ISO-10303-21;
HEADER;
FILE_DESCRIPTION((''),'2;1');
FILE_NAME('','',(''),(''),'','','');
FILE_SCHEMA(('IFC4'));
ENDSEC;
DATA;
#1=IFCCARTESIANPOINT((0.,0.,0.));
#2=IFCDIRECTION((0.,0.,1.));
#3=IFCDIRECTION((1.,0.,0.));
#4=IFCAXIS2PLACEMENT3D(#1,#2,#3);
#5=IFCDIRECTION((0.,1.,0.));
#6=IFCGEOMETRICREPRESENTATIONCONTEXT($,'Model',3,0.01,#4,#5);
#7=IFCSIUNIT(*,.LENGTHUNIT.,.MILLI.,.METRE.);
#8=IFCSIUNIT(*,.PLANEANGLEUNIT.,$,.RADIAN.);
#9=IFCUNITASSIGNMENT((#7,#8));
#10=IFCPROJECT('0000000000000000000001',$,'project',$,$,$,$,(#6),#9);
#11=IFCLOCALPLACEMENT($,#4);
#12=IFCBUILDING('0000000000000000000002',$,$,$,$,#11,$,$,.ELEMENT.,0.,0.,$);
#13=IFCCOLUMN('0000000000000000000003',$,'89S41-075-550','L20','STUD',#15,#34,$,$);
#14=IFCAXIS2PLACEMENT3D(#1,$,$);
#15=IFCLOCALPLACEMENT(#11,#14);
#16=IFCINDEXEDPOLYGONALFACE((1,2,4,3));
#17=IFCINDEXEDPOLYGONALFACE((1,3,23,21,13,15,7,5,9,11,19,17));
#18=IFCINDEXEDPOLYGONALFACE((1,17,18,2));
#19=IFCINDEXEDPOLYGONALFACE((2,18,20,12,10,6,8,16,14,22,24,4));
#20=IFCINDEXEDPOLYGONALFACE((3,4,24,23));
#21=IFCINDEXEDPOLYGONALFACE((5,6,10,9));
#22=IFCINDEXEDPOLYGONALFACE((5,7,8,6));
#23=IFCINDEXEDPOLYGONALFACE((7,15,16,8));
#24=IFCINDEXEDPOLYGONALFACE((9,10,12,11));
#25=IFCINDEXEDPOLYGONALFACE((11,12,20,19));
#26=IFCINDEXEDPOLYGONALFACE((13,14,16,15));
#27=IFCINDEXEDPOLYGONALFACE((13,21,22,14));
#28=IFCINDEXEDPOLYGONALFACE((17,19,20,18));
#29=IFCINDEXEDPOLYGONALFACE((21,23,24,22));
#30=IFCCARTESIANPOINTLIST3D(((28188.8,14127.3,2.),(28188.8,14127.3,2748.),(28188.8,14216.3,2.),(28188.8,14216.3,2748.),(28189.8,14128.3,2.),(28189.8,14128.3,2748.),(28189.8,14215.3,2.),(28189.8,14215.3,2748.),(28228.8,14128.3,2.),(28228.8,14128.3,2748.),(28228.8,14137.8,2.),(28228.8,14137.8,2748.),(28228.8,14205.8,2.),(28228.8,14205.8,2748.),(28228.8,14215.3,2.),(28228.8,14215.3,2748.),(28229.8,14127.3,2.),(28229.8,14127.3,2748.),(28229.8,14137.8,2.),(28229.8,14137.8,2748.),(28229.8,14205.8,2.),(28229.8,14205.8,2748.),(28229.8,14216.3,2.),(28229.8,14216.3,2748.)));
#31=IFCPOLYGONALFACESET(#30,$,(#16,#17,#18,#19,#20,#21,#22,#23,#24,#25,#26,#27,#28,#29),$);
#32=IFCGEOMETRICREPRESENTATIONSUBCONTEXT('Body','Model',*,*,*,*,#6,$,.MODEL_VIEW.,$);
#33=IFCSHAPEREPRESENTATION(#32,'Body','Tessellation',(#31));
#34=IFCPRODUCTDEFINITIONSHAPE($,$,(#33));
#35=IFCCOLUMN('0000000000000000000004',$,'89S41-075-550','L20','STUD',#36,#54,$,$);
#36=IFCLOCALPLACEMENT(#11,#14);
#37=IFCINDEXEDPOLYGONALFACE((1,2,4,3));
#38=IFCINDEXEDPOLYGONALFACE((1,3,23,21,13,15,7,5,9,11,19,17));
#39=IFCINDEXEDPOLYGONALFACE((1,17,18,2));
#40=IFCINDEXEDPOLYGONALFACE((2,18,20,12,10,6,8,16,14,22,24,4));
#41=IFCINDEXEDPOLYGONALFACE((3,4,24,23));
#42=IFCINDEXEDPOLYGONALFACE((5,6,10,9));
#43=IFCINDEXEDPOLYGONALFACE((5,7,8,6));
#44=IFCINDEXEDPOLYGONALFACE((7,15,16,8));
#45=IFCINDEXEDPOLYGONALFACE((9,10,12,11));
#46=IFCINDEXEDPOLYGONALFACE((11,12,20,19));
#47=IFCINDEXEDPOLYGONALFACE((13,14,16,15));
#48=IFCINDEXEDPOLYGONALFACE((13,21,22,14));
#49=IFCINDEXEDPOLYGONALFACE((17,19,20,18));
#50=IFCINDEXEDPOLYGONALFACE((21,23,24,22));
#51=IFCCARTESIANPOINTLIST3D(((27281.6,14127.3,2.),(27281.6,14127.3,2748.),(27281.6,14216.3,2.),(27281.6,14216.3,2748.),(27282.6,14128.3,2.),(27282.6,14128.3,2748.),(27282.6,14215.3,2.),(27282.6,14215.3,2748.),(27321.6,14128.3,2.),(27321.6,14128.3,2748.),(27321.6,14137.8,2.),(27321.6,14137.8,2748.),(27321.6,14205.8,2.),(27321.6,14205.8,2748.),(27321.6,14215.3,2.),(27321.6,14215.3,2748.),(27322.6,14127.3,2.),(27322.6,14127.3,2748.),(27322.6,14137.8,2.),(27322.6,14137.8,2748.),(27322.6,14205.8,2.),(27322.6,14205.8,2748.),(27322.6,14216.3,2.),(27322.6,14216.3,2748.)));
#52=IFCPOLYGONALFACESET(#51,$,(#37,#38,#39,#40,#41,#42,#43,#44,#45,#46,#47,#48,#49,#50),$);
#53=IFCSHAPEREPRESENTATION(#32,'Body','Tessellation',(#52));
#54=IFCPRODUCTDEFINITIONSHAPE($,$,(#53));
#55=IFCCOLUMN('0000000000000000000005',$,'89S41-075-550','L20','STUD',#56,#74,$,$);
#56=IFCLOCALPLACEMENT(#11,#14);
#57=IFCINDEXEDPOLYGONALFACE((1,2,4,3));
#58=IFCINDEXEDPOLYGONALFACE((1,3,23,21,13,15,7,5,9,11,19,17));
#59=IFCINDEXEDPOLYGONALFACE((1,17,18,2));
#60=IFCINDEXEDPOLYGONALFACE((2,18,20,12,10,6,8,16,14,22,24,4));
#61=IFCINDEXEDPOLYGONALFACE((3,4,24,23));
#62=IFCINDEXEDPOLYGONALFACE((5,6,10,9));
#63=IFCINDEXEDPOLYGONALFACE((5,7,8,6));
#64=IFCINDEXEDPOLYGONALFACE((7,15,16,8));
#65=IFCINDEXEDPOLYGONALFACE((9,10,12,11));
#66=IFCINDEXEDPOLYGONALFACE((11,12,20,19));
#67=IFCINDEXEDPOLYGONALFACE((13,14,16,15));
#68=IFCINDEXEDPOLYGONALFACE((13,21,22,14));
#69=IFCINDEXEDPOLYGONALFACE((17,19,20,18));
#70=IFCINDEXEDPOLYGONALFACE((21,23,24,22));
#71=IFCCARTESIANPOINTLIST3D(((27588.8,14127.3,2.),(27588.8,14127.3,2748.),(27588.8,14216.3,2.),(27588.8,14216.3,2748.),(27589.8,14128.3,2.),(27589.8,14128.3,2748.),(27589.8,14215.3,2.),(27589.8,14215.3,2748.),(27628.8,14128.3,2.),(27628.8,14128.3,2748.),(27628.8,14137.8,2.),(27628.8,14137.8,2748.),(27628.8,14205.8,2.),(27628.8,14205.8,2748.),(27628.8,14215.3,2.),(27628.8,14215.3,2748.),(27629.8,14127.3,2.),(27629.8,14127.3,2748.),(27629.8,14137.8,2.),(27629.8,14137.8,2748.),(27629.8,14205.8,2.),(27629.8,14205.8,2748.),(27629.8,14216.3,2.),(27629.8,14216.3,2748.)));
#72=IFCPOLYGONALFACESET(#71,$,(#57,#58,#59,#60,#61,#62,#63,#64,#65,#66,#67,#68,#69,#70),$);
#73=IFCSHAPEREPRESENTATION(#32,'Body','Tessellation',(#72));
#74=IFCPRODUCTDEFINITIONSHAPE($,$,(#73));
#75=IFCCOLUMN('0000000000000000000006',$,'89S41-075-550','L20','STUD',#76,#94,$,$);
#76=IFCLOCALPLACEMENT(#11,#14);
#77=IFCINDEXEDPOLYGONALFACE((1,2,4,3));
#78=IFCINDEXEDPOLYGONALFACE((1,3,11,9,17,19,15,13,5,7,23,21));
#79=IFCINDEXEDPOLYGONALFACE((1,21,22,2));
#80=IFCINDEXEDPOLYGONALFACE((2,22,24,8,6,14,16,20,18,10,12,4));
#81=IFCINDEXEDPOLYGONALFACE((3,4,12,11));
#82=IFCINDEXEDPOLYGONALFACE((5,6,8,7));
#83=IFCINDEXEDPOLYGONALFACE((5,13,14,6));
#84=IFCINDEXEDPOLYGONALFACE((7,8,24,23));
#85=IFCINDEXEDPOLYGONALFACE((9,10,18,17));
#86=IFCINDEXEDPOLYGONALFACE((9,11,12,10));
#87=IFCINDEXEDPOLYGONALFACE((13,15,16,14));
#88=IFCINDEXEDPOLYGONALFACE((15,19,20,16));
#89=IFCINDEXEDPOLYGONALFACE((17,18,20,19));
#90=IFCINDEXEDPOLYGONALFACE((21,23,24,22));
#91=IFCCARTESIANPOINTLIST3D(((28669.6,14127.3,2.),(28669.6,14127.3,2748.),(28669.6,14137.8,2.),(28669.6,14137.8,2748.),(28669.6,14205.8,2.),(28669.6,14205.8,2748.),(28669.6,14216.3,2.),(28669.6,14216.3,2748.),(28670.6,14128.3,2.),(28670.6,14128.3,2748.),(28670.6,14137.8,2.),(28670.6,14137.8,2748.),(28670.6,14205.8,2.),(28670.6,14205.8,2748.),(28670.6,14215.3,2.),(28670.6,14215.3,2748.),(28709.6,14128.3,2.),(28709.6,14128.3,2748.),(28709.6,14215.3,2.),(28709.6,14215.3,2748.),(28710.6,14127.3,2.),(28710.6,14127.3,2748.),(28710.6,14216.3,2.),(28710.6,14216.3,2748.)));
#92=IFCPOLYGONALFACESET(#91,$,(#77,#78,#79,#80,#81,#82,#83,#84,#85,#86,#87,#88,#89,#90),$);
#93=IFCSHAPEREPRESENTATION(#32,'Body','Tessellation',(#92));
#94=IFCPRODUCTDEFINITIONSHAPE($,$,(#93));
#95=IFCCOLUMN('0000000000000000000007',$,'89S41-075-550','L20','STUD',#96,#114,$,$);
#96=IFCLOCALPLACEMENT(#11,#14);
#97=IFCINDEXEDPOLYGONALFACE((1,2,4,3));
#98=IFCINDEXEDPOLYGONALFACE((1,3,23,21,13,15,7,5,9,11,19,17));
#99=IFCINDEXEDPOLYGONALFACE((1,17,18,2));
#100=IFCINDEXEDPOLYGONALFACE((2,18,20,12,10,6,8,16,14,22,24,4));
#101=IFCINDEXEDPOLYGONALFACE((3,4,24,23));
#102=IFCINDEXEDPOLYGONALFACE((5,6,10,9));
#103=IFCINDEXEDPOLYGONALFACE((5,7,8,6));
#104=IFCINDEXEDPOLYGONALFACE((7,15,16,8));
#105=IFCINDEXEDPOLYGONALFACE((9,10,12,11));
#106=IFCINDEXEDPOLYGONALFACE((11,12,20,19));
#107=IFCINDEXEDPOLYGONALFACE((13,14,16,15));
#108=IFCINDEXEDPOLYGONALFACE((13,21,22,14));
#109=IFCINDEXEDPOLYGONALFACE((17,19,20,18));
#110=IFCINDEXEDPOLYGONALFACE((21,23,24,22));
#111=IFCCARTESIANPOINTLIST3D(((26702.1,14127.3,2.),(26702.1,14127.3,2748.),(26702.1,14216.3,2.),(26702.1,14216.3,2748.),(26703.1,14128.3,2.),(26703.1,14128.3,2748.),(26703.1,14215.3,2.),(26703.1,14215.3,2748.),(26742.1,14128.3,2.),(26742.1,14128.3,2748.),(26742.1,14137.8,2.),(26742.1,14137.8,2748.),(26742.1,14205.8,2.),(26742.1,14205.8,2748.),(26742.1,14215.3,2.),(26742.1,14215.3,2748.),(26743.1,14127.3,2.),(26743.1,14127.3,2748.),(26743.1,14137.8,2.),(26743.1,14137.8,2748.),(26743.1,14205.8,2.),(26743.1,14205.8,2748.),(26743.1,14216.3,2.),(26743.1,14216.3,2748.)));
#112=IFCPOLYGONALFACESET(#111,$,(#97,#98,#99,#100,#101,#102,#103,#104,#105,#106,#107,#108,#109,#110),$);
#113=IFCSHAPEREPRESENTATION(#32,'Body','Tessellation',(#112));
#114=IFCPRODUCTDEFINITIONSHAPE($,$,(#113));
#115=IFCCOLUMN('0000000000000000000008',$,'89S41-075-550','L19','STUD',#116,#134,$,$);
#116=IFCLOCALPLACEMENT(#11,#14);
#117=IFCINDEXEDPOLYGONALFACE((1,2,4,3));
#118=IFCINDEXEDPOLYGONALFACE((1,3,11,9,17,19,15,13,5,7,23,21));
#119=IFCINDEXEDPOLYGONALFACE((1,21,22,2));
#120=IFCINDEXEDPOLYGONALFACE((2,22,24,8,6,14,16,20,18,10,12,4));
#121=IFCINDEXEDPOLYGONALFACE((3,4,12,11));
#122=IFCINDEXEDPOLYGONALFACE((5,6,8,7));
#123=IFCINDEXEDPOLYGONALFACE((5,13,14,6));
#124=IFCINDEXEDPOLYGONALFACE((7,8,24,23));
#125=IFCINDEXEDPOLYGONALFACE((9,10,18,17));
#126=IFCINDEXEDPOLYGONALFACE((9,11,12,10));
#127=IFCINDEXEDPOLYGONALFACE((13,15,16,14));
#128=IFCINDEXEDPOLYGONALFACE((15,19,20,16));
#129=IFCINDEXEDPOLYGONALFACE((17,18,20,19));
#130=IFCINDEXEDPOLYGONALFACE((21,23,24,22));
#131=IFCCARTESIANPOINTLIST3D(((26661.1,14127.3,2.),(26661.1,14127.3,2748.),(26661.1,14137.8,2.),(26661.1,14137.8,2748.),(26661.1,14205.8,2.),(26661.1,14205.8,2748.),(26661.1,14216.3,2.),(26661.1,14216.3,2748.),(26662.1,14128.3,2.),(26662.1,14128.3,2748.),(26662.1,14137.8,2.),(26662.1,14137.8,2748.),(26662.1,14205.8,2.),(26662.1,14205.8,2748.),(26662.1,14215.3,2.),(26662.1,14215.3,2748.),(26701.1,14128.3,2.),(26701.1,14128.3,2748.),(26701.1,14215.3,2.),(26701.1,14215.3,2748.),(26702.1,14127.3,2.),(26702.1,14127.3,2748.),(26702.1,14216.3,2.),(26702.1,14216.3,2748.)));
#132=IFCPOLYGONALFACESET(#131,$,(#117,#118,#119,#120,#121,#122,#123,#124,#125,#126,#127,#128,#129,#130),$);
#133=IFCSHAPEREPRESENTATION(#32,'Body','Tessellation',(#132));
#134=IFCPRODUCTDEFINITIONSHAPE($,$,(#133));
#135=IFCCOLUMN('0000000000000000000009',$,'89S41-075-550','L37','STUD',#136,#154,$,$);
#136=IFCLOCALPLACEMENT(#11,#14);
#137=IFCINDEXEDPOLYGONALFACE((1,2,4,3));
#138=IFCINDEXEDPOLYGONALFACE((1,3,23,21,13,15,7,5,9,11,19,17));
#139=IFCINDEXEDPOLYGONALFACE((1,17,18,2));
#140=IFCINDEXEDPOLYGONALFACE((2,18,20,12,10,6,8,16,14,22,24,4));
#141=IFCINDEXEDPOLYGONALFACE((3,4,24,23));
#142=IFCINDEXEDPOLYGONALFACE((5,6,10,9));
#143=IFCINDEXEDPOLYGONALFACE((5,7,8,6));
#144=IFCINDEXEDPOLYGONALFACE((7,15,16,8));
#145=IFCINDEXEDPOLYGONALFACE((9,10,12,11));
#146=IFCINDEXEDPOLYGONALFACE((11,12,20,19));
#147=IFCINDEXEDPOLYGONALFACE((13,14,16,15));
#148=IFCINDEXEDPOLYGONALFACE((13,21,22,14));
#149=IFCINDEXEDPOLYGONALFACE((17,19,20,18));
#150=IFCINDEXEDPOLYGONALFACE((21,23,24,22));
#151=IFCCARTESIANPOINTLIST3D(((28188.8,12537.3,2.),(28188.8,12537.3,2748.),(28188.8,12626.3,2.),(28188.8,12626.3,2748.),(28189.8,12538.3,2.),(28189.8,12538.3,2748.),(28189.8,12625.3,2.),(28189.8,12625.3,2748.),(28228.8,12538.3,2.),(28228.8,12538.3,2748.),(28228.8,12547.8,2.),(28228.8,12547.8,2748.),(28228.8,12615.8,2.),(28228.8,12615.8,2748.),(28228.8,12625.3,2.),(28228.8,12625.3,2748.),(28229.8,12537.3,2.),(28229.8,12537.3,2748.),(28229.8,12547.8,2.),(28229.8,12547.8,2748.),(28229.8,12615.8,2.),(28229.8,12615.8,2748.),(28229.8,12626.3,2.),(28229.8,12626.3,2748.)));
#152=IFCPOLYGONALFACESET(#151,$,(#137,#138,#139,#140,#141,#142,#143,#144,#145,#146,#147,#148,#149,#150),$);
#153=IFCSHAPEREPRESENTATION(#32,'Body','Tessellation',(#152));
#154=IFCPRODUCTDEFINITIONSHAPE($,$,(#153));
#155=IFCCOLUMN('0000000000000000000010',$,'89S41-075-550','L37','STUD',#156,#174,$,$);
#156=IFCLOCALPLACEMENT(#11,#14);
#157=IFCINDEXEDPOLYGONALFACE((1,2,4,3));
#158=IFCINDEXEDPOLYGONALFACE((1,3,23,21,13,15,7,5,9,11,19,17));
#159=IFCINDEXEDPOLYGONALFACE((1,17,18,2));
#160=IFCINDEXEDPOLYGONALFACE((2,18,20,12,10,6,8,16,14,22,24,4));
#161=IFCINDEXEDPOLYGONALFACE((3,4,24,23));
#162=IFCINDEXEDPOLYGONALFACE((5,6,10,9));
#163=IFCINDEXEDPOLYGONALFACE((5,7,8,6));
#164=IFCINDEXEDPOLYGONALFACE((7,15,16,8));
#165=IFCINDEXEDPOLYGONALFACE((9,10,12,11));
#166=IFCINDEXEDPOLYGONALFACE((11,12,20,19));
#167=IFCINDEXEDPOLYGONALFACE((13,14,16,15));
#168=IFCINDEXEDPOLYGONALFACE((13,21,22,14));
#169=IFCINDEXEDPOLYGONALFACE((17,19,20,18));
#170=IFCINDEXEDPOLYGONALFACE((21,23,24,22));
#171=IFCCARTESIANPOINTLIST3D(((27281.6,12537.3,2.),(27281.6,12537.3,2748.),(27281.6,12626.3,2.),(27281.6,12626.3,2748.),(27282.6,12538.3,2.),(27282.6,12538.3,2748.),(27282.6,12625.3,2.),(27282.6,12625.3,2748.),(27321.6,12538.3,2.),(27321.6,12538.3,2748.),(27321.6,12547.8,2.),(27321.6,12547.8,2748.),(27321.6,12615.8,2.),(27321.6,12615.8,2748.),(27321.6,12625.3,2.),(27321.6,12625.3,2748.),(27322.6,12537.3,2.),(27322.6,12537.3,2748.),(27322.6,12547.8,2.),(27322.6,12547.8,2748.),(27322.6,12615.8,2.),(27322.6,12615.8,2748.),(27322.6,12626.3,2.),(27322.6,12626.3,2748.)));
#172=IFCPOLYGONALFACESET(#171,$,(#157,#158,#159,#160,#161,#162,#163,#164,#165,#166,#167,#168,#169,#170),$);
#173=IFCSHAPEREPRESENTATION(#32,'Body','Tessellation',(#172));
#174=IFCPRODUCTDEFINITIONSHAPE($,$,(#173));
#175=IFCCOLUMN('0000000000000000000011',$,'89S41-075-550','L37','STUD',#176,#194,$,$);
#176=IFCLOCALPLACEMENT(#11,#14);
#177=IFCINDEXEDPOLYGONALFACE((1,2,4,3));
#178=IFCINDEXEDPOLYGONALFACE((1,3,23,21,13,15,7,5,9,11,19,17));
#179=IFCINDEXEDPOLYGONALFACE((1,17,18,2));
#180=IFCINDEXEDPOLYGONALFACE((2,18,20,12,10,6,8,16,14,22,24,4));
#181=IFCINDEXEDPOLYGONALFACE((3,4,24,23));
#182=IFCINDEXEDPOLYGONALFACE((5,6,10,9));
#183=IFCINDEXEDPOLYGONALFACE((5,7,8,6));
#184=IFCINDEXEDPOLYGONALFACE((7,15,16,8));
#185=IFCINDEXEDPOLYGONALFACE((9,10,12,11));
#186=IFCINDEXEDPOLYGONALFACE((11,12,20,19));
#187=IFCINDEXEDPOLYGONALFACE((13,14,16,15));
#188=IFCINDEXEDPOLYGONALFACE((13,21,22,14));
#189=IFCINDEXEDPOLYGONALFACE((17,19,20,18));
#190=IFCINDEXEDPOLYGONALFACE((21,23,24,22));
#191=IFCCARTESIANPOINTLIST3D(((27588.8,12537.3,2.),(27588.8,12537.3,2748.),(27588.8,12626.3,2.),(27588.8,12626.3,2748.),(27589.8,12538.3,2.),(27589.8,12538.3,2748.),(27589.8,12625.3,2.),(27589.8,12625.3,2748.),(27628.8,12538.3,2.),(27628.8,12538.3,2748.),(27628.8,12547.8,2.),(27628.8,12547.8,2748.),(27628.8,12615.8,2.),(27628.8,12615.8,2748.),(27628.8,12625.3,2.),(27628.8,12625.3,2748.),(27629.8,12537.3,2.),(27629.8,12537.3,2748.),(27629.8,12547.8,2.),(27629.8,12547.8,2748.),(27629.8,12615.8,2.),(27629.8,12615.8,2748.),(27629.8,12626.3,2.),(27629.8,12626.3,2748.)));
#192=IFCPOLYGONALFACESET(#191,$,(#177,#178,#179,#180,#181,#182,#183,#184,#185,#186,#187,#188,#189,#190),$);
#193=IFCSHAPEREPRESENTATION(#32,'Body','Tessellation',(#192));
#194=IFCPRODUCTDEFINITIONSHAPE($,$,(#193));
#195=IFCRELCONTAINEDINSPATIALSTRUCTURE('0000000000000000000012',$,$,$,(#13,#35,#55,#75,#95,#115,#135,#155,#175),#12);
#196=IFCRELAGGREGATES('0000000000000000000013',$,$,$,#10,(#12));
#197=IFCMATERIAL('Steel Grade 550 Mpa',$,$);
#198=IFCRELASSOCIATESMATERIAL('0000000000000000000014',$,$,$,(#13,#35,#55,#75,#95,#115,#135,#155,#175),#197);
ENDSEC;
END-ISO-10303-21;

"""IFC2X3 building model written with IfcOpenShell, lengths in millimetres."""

from ifc_helpers import new_model, si_unit, direction, frame, origin, origin_with_axes, origin_2d_with_axis, place, context, subcontext, project, spatial, c_section, extrude, source, transform, mapped, material, element, save


model = new_model("IFC2X3")

# Units and contexts
model_context = context("Model", 3, precision=0.01, world=origin_with_axes(), true_north=direction((0.0, 1.0, 0.0)))
body_context = subcontext(model_context, "Body", "Model", "MODEL_VIEW")
ifc_project = project(units=[si_unit("LENGTHUNIT", "METRE", prefix="MILLI"), si_unit("PLANEANGLEUNIT", "RADIAN")], contexts=[model_context])

# Building
building_placement = place(None, origin_with_axes())
building = spatial("IfcBuilding", under=ifc_project, at=building_placement, CompositionType="ELEMENT", ElevationOfRefHeight=0.0, ElevationOfTerrain=0.0)

# Columns
ifc_material = material(Name="Steel Grade 550 Mpa")
shared_shape_1 = source(origin(), body_context, "Body", "SweptSolid", [
    extrude(c_section(Depth=89.0, Width=41.0, WallThickness=1.0, Girth=10.5, at=origin_2d_with_axis()), origin_with_axes(), (0.0, 0.0, 1.0), 2746.0),
])
column_1_placement = place(None, frame((28209.3, 14171.8, 2.0), z_axis=(0.0, 0.0, 1.0), x_axis=(1.0, 0.0, 0.0)))
element("IfcColumn", 1, at=column_1_placement, inside=building, material=ifc_material, Name="89S41-075-550", Description="L20", ObjectType="STUD", context=body_context, shape_type="MappedRepresentation", body=[
    mapped(shared_shape_1, transform((0.0, 0.0, 0.0), scale=1.0)),
])
shared_shape_2 = source(origin(), body_context, "Body", "SweptSolid", [
    extrude(c_section(Depth=89.0, Width=41.0, WallThickness=1.0, Girth=10.5, at=origin_2d_with_axis()), origin_with_axes(), (0.0, 0.0, 1.0), 2746.0),
])
column_2_placement = place(None, frame((27302.1, 14171.8, 2.0), z_axis=(0.0, 0.0, 1.0), x_axis=(1.0, 0.0, 0.0)))
element("IfcColumn", 2, at=column_2_placement, inside=building, material=ifc_material, Name="89S41-075-550", Description="L20", ObjectType="STUD", context=body_context, shape_type="MappedRepresentation", body=[
    mapped(shared_shape_2, transform((0.0, 0.0, 0.0), scale=1.0)),
])
shared_shape_3 = source(origin(), body_context, "Body", "SweptSolid", [
    extrude(c_section(Depth=89.0, Width=41.0, WallThickness=1.0, Girth=10.5, at=origin_2d_with_axis()), origin_with_axes(), (0.0, 0.0, 1.0), 2746.0),
])
column_3_placement = place(None, frame((27609.3, 14171.8, 2.0), z_axis=(0.0, 0.0, 1.0), x_axis=(1.0, 0.0, 0.0)))
element("IfcColumn", 3, at=column_3_placement, inside=building, material=ifc_material, Name="89S41-075-550", Description="L20", ObjectType="STUD", context=body_context, shape_type="MappedRepresentation", body=[
    mapped(shared_shape_3, transform((0.0, 0.0, 0.0), scale=1.0)),
])
shared_shape_4 = source(origin(), body_context, "Body", "SweptSolid", [
    extrude(c_section(Depth=89.0, Width=41.0, WallThickness=1.0, Girth=10.5, at=origin_2d_with_axis()), origin_with_axes(), (0.0, 0.0, 1.0), 2746.0),
])
column_4_placement = place(None, frame((28690.1, 14171.8, 2.0), z_axis=(0.0, 0.0, 1.0), x_axis=(-1.0, 0.0, 0.0)))
element("IfcColumn", 4, at=column_4_placement, inside=building, material=ifc_material, Name="89S41-075-550", Description="L20", ObjectType="STUD", context=body_context, shape_type="MappedRepresentation", body=[
    mapped(shared_shape_4, transform((0.0, 0.0, 0.0), scale=1.0)),
])
shared_shape_5 = source(origin(), body_context, "Body", "SweptSolid", [
    extrude(c_section(Depth=89.0, Width=41.0, WallThickness=1.0, Girth=10.5, at=origin_2d_with_axis()), origin_with_axes(), (0.0, 0.0, 1.0), 2746.0),
])
column_5_placement = place(None, frame((26722.6, 14171.8, 2.0), z_axis=(0.0, 0.0, 1.0), x_axis=(1.0, 0.0, 0.0)))
element("IfcColumn", 5, at=column_5_placement, inside=building, material=ifc_material, Name="89S41-075-550", Description="L20", ObjectType="STUD", context=body_context, shape_type="MappedRepresentation", body=[
    mapped(shared_shape_5, transform((0.0, 0.0, 0.0), scale=1.0)),
])
shared_shape_6 = source(origin(), body_context, "Body", "SweptSolid", [
    extrude(c_section(Depth=89.0, Width=41.0, WallThickness=1.0, Girth=10.5, at=origin_2d_with_axis()), origin_with_axes(), (0.0, 0.0, 1.0), 2746.0),
])
column_6_placement = place(None, frame((26681.6, 14171.8, 2.0), z_axis=(0.0, 0.0, 1.0), x_axis=(-1.0, 0.0, 0.0)))
element("IfcColumn", 6, at=column_6_placement, inside=building, material=ifc_material, Name="89S41-075-550", Description="L19", ObjectType="STUD", context=body_context, shape_type="MappedRepresentation", body=[
    mapped(shared_shape_6, transform((0.0, 0.0, 0.0), scale=1.0)),
])
shared_shape_7 = source(origin(), body_context, "Body", "SweptSolid", [
    extrude(c_section(Depth=89.0, Width=41.0, WallThickness=1.0, Girth=10.5, at=origin_2d_with_axis()), origin_with_axes(), (0.0, 0.0, 1.0), 2746.0),
])
column_7_placement = place(None, frame((28209.3, 12581.8, 2.0), z_axis=(0.0, 0.0, 1.0), x_axis=(1.0, 0.0, 0.0)))
element("IfcColumn", 7, at=column_7_placement, inside=building, material=ifc_material, Name="89S41-075-550", Description="L37", ObjectType="STUD", context=body_context, shape_type="MappedRepresentation", body=[
    mapped(shared_shape_7, transform((0.0, 0.0, 0.0), scale=1.0)),
])
shared_shape_8 = source(origin(), body_context, "Body", "SweptSolid", [
    extrude(c_section(Depth=89.0, Width=41.0, WallThickness=1.0, Girth=10.5, at=origin_2d_with_axis()), origin_with_axes(), (0.0, 0.0, 1.0), 2746.0),
])
column_8_placement = place(None, frame((27302.1, 12581.8, 2.0), z_axis=(0.0, 0.0, 1.0), x_axis=(1.0, 0.0, 0.0)))
element("IfcColumn", 8, at=column_8_placement, inside=building, material=ifc_material, Name="89S41-075-550", Description="L37", ObjectType="STUD", context=body_context, shape_type="MappedRepresentation", body=[
    mapped(shared_shape_8, transform((0.0, 0.0, 0.0), scale=1.0)),
])
shared_shape_9 = source(origin(), body_context, "Body", "SweptSolid", [
    extrude(c_section(Depth=89.0, Width=41.0, WallThickness=1.0, Girth=10.5, at=origin_2d_with_axis()), origin_with_axes(), (0.0, 0.0, 1.0), 2746.0),
])
column_9_placement = place(None, frame((27609.3, 12581.8, 2.0), z_axis=(0.0, 0.0, 1.0), x_axis=(1.0, 0.0, 0.0)))
element("IfcColumn", 9, at=column_9_placement, inside=building, material=ifc_material, Name="89S41-075-550", Description="L37", ObjectType="STUD", context=body_context, shape_type="MappedRepresentation", body=[
    mapped(shared_shape_9, transform((0.0, 0.0, 0.0), scale=1.0)),
])

save(model, "model.ifc")
